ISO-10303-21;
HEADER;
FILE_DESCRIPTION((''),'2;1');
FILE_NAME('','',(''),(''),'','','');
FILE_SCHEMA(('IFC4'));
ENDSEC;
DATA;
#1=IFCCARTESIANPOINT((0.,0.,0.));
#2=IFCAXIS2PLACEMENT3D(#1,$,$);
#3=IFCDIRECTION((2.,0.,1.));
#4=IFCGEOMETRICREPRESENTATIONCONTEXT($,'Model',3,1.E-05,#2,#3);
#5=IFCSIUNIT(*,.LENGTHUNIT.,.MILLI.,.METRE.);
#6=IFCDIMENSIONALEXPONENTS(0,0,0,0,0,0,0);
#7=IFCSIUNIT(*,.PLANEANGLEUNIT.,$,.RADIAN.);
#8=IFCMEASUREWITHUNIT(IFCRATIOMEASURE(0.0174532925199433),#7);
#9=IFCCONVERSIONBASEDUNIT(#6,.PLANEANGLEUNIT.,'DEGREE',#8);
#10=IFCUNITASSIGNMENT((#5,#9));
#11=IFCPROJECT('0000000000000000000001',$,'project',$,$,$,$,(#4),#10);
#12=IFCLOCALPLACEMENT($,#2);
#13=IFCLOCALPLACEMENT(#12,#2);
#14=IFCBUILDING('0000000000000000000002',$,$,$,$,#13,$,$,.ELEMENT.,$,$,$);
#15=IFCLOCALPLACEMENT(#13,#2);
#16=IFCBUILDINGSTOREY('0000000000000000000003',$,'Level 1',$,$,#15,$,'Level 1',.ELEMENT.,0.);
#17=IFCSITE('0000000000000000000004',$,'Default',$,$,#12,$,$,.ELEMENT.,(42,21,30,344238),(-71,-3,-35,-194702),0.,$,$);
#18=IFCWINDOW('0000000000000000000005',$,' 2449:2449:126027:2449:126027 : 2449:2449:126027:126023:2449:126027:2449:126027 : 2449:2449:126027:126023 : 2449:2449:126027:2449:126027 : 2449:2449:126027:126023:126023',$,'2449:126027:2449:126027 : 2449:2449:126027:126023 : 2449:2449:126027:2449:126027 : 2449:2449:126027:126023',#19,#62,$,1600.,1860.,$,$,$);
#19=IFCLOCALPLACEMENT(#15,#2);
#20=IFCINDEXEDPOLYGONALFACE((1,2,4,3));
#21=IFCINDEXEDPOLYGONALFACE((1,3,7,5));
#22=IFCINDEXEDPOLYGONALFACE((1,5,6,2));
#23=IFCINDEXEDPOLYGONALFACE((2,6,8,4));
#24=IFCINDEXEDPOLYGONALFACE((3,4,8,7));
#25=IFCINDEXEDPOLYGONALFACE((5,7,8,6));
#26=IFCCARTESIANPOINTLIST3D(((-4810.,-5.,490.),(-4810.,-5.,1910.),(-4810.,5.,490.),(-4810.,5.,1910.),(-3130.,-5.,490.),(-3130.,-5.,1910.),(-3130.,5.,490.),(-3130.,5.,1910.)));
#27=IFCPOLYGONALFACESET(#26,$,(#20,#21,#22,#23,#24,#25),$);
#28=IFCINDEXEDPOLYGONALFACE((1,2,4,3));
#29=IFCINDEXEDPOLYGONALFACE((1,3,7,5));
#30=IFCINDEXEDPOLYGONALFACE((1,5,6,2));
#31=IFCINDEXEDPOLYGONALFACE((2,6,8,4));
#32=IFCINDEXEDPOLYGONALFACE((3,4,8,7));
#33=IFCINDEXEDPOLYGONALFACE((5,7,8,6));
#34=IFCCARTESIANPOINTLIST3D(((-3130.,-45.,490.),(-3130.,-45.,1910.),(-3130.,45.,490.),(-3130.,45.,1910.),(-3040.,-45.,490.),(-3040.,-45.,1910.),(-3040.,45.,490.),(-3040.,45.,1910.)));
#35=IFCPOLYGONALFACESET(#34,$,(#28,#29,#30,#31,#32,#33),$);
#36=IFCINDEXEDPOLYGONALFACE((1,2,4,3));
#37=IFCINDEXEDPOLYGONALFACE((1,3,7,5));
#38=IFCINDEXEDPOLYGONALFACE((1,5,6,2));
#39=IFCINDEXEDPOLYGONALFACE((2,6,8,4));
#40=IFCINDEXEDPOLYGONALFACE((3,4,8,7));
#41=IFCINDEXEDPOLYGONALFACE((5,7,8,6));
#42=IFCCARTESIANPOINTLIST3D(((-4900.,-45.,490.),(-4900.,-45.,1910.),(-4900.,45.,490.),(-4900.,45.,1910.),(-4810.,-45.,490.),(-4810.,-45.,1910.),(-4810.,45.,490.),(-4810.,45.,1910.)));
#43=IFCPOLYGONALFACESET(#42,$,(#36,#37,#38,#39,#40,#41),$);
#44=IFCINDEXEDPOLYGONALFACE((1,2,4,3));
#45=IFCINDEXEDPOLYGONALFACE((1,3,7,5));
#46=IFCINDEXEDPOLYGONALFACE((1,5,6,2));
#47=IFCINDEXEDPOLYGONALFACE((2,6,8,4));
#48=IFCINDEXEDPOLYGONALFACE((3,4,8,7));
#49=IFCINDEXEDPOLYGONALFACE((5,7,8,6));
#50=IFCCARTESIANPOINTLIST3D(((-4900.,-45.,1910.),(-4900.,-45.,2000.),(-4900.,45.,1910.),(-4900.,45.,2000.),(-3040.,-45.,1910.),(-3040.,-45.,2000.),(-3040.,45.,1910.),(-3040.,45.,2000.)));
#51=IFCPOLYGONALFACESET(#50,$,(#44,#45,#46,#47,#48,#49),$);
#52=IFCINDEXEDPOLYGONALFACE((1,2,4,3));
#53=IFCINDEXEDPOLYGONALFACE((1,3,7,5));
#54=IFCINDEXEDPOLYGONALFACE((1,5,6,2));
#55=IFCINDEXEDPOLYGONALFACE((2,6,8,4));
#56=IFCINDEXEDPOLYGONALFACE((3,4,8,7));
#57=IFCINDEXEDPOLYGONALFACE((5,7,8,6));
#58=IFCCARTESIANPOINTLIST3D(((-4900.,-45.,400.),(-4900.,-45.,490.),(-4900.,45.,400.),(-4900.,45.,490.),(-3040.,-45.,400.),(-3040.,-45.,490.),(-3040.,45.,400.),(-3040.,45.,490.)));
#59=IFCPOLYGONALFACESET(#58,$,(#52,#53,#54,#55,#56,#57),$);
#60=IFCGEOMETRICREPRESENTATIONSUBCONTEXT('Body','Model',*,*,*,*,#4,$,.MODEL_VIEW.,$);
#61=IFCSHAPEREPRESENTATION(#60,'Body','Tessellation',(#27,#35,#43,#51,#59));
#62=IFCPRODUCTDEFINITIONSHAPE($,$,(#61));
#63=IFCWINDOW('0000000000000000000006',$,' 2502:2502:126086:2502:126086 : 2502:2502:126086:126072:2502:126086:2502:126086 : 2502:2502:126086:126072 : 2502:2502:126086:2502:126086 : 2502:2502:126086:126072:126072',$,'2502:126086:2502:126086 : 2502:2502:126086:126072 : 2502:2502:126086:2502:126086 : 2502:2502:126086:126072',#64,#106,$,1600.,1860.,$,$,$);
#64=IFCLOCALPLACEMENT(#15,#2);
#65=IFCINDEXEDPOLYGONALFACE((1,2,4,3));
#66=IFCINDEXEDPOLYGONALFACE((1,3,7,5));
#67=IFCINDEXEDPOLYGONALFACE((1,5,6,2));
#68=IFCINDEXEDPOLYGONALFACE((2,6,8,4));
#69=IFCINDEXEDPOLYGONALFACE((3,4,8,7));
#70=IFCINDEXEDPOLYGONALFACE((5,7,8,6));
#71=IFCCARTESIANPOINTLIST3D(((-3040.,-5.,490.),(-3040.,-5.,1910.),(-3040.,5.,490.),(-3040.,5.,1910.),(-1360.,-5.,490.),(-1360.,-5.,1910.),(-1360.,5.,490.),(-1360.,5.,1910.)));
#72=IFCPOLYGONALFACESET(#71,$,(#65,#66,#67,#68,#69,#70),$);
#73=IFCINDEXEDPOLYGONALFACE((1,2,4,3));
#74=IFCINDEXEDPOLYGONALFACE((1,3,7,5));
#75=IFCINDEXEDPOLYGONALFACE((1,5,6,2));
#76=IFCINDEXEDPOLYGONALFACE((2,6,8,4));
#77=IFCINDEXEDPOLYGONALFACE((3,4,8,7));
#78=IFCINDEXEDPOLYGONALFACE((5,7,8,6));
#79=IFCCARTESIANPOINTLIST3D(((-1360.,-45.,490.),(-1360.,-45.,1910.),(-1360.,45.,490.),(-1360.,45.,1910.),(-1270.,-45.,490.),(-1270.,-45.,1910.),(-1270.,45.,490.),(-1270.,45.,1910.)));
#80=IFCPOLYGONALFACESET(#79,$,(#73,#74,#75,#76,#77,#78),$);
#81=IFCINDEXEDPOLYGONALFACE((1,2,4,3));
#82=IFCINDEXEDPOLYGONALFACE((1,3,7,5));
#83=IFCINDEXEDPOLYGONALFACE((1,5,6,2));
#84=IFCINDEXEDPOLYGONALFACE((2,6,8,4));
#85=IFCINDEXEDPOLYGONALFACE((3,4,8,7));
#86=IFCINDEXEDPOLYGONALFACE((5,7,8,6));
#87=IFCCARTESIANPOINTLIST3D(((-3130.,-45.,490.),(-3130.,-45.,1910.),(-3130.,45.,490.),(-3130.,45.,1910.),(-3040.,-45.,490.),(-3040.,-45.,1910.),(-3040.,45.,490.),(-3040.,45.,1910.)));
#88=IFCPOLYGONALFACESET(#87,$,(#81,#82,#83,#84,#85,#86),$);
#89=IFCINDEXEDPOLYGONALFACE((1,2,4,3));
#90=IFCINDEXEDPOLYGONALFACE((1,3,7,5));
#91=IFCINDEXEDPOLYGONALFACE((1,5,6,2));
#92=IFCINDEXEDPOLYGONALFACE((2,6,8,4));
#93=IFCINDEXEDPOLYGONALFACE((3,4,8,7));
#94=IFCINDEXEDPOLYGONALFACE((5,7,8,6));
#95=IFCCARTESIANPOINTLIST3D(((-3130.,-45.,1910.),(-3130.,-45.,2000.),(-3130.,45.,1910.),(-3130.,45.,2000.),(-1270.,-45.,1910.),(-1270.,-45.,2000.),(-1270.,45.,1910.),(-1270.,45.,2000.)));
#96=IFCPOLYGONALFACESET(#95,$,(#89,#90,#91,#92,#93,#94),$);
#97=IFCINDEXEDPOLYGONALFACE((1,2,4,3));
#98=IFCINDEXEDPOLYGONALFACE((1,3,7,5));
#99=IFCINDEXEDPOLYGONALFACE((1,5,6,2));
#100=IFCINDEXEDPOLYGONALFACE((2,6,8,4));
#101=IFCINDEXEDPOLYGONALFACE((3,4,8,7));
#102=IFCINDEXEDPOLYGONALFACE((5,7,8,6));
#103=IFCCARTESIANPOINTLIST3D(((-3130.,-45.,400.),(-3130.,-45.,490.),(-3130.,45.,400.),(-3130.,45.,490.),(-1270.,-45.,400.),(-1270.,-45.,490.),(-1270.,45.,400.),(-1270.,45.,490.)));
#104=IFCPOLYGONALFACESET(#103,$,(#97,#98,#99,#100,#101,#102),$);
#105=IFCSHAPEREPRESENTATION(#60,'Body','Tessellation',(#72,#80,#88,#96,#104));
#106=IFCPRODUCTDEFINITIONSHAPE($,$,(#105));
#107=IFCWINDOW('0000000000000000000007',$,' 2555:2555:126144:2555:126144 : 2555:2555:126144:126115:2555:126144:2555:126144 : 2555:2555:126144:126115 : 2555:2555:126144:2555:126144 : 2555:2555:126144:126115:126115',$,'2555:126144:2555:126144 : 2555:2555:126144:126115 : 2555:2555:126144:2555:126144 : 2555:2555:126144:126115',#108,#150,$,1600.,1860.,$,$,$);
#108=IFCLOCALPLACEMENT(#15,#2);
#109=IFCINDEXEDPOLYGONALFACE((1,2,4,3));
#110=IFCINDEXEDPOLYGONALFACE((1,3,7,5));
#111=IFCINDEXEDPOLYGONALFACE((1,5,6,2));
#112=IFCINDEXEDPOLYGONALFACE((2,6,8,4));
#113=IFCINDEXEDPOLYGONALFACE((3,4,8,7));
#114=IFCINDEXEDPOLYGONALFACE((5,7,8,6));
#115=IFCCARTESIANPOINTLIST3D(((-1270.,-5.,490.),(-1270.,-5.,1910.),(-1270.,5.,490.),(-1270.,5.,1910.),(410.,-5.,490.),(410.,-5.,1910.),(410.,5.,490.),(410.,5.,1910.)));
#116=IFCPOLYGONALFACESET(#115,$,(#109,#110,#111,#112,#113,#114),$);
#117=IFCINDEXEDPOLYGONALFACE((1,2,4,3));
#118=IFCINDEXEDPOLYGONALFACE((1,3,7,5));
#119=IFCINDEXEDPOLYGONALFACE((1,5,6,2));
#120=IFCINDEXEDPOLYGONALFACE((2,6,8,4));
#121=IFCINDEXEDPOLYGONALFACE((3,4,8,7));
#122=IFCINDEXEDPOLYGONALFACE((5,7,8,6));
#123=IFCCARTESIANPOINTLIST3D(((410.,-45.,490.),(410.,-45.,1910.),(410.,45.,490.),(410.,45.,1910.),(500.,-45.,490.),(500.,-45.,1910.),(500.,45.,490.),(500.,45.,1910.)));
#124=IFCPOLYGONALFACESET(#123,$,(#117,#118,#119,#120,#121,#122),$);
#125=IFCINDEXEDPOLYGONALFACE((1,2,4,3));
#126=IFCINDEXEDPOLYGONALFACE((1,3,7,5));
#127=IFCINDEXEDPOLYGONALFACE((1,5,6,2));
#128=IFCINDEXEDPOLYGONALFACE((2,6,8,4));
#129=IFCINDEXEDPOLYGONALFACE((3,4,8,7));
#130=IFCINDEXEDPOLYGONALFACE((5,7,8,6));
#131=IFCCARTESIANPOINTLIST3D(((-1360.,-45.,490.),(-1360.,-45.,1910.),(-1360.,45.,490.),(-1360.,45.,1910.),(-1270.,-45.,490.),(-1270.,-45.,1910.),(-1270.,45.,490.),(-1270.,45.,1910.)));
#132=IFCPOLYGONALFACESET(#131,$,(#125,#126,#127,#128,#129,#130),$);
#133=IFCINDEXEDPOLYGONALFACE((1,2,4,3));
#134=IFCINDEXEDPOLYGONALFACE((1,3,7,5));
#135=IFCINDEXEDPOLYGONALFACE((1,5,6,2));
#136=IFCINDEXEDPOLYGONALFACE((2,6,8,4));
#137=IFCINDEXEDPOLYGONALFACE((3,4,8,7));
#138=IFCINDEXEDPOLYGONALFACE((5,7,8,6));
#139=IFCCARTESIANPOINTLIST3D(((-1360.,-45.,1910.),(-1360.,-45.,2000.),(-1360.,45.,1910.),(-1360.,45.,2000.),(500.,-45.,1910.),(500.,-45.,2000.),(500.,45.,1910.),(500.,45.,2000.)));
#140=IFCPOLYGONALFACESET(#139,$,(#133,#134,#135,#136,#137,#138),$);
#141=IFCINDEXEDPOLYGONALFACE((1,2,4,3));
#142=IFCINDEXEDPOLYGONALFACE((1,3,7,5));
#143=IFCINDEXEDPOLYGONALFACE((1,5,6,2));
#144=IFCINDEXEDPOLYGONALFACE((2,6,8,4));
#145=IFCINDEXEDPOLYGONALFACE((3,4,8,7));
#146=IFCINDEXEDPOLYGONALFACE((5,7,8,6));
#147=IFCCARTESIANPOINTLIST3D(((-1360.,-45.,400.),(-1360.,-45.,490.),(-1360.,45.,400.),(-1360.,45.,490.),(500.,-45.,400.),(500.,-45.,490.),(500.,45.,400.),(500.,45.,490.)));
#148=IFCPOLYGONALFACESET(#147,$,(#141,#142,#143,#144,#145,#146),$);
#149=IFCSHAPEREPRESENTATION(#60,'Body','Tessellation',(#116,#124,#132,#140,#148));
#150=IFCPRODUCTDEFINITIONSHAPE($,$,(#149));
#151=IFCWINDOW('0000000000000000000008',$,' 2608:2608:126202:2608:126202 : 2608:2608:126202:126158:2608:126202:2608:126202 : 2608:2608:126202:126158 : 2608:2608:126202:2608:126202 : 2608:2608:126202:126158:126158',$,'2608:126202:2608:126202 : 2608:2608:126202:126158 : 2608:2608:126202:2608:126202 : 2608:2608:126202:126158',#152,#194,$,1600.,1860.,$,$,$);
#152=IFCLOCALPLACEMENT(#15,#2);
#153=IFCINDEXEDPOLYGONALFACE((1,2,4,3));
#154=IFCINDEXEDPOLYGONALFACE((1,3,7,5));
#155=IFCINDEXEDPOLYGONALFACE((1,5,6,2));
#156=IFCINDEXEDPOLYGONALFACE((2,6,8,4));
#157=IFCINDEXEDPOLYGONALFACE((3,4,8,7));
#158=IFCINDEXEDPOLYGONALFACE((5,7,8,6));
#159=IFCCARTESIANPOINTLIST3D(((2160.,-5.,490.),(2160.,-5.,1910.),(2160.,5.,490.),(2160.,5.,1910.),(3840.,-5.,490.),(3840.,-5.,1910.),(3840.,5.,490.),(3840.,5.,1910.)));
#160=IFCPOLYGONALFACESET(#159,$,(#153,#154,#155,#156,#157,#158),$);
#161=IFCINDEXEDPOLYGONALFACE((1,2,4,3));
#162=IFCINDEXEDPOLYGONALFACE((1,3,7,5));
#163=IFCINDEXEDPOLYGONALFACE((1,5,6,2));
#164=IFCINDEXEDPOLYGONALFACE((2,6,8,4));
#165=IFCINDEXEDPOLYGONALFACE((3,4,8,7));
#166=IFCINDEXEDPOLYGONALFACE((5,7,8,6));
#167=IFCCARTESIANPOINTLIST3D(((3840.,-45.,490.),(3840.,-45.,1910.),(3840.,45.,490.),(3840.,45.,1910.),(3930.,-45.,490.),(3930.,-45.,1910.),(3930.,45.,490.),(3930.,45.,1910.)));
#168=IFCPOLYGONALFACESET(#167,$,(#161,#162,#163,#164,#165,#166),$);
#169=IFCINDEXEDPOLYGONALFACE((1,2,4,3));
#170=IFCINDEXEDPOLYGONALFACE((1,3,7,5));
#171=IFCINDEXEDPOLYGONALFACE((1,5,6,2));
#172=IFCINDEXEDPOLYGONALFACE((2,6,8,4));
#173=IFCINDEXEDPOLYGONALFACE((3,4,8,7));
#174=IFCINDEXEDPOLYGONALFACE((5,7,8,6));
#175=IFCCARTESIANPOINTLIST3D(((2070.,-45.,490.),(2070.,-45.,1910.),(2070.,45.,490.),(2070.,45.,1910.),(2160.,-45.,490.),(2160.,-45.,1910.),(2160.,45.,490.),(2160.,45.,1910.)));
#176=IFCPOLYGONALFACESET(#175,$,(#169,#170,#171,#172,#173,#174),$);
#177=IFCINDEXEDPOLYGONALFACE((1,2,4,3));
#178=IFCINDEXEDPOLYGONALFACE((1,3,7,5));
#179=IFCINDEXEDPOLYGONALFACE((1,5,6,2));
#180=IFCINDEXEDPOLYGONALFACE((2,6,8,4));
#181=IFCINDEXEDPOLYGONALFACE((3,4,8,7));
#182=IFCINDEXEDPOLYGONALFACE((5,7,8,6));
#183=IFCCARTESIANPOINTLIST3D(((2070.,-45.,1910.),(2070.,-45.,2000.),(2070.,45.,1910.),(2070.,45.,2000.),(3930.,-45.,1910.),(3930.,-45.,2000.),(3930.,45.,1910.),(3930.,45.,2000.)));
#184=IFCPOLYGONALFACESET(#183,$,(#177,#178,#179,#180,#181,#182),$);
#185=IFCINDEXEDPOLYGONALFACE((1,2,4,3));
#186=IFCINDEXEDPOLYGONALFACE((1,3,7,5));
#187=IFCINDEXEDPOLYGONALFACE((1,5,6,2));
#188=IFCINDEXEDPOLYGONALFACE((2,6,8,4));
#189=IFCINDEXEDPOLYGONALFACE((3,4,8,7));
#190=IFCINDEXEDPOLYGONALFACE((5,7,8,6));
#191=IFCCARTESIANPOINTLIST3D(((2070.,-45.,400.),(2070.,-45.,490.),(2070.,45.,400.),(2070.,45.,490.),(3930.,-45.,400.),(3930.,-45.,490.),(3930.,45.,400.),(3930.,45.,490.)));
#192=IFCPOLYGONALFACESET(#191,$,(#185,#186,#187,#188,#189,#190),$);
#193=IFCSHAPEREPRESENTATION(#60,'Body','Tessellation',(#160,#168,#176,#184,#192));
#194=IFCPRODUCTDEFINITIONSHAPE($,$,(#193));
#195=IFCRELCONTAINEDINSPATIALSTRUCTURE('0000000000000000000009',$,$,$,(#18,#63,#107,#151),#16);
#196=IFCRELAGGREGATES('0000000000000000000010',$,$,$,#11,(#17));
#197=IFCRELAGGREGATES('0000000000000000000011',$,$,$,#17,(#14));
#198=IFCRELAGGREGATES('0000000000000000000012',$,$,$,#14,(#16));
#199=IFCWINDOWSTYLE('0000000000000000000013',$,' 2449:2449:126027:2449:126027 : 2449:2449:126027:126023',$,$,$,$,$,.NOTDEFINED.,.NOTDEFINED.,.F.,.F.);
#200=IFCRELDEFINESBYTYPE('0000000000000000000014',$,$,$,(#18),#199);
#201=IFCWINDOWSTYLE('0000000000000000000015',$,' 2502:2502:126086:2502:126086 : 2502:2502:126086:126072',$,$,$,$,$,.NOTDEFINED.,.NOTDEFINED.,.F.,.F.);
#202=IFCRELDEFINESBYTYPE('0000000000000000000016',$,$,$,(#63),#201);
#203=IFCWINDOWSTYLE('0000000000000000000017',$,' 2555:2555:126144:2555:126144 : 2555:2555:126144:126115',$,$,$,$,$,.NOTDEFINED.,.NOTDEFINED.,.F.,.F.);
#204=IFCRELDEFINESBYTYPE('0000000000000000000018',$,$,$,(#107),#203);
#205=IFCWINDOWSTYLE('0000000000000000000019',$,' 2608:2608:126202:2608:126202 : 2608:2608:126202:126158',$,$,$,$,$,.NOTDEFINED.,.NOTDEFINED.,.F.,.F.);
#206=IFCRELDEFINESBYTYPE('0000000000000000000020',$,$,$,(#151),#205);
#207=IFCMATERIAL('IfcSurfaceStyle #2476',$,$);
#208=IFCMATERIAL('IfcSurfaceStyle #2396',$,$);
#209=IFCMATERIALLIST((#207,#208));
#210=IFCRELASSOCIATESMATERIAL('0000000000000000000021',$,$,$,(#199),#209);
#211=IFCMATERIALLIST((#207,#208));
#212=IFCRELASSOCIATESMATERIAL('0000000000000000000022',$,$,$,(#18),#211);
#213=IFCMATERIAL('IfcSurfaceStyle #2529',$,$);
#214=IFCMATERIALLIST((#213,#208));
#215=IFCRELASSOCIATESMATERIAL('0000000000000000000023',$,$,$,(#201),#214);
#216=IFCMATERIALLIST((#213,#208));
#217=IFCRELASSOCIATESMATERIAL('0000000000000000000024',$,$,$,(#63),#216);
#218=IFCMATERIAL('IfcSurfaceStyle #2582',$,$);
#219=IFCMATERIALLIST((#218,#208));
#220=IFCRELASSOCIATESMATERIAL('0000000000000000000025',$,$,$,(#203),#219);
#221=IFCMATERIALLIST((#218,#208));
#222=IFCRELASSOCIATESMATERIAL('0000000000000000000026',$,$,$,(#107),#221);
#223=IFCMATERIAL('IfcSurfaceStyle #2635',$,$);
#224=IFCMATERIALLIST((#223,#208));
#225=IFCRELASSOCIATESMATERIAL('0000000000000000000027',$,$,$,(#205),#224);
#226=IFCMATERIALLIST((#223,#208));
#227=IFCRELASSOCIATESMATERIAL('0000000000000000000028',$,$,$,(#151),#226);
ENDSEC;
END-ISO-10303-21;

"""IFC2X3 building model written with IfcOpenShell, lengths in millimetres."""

from ifc_helpers import new_model, entity, si_unit, converted_unit, direction, frame, frame_2d, origin, origin_2d_with_axis, place, context, subcontext, project, spatial, rectangle, extrude, source, transform, mapped, material, material_list, type_object, type_shapes, element, save


model = new_model("IFC2X3")

# Units and contexts
model_context = context("Model", 3, precision=1e-05, world=origin(), true_north=direction((2.0, 0.0, 1.0)))
body_context = subcontext(model_context, "Body", "Model", "MODEL_VIEW")
ifc_project = project(units=[si_unit("LENGTHUNIT", "METRE", prefix="MILLI"), converted_unit("PLANEANGLEUNIT", "DEGREE", entity("IfcRatioMeasure", 0.0174532925199433), si_unit("PLANEANGLEUNIT", "RADIAN"), dimensions=[0, 0, 0, 0, 0, 0, 0])], contexts=[model_context])

# Site, building, storey
site_placement = place(None, origin())
site = spatial("IfcSite", under=ifc_project, at=site_placement, Name="Default", CompositionType="ELEMENT", RefLatitude=(42, 21, 30, 344238), RefLongitude=(-71, -3, -35, -194702), RefElevation=0.0)
building_placement = place(site_placement, origin())
building = spatial("IfcBuilding", under=site, at=building_placement, CompositionType="ELEMENT")
storey_placement = place(building_placement, origin())
storey = spatial("IfcBuildingStorey", under=building, at=storey_placement, Name="Level 1", LongName="Level 1", CompositionType="ELEMENT", Elevation=0.0)

# Windows
ifc_material_1 = material(Name="IfcSurfaceStyle #2476")
ifc_material_2 = material(Name="IfcSurfaceStyle #2396")
ifc_material_list_1 = material_list([ifc_material_1, ifc_material_2])
ifc_material_list_2 = material_list([ifc_material_1, ifc_material_2])
window_style_1 = type_object("IfcWindowStyle", Name=" 2449:2449:126027:2449:126027 : 2449:2449:126027:126023", ConstructionType="NOTDEFINED", OperationType="NOTDEFINED", ParameterTakesPrecedence=False, Sizeable=False, material=ifc_material_list_2)
shared_shape_1 = source(origin(), body_context, "Body", "SweptSolid", [
    extrude(rectangle(XDim=10.0, YDim=1680.0, at=origin_2d_with_axis()), frame((-3970.0, 0.0, 490.0), z_axis=(0.0, 0.0, 1.0), x_axis=(0.0, -1.0, 0.0)), (0.0, 0.0, 1.0), 1420.0),
    extrude(rectangle(XDim=90.0, YDim=90.0, at=origin_2d_with_axis()), frame((-3085.0, 0.0, 490.0), z_axis=(0.0, 0.0, 1.0), x_axis=(0.0, -1.0, 0.0)), (0.0, 0.0, 1.0), 1420.0),
    extrude(rectangle(XDim=90.0, YDim=90.0, at=frame_2d((0.0, 0.0), x_axis=(1.0, 0.0))), frame((-4855.0, 0.0, 490.0), z_axis=(0.0, 0.0, 1.0), x_axis=(0.0, -1.0, 0.0)), (0.0, 0.0, 1.0), 1420.0),
    extrude(rectangle(XDim=90.0, YDim=1860.0, at=frame_2d((0.0, 0.0), x_axis=(1.0, 0.0))), frame((-3970.0, 0.0, 1910.0), z_axis=(0.0, 0.0, 1.0), x_axis=(0.0, -1.0, 0.0)), (0.0, 0.0, 1.0), 90.0),
    extrude(rectangle(XDim=90.0, YDim=1860.0, at=frame_2d((0.0, 0.0), x_axis=(1.0, 0.0))), frame((-3970.0, 0.0, 400.0), z_axis=(0.0, 0.0, 1.0), x_axis=(0.0, -1.0, 0.0)), (0.0, 0.0, 1.0), 90.0),
])
type_shapes(window_style_1, [shared_shape_1])
window_1_placement = place(storey_placement, origin())
element("IfcWindow", 1, at=window_1_placement, inside=storey, type_object=window_style_1, material=ifc_material_list_1, Name=" 2449:2449:126027:2449:126027 : 2449:2449:126027:126023:2449:126027:2449:126027 : 2449:2449:126027:126023 : 2449:2449:126027:2449:126027 : 2449:2449:126027:126023:126023", ObjectType="2449:126027:2449:126027 : 2449:2449:126027:126023 : 2449:2449:126027:2449:126027 : 2449:2449:126027:126023", OverallHeight=1600.0, OverallWidth=1860.0, context=body_context, shape_type="MappedRepresentation", body=[
    mapped(shared_shape_1, transform((0.0, 0.0, 0.0), scale=1.0)),
])
ifc_material_3 = material(Name="IfcSurfaceStyle #2529")
ifc_material_list_3 = material_list([ifc_material_3, ifc_material_2])
ifc_material_list_4 = material_list([ifc_material_3, ifc_material_2])
window_style_2 = type_object("IfcWindowStyle", Name=" 2502:2502:126086:2502:126086 : 2502:2502:126086:126072", ConstructionType="NOTDEFINED", OperationType="NOTDEFINED", ParameterTakesPrecedence=False, Sizeable=False, material=ifc_material_list_4)
shared_shape_2 = source(origin(), body_context, "Body", "SweptSolid", [
    extrude(rectangle(XDim=10.0, YDim=1680.0, at=origin_2d_with_axis()), frame((-2200.0, 0.0, 490.0), z_axis=(0.0, 0.0, 1.0), x_axis=(0.0, -1.0, 0.0)), (0.0, 0.0, 1.0), 1420.0),
    extrude(rectangle(XDim=90.0, YDim=90.0, at=origin_2d_with_axis()), frame((-1315.0, 0.0, 490.0), z_axis=(0.0, 0.0, 1.0), x_axis=(0.0, -1.0, 0.0)), (0.0, 0.0, 1.0), 1420.0),
    extrude(rectangle(XDim=90.0, YDim=90.0, at=origin_2d_with_axis()), frame((-3085.0, 0.0, 490.0), z_axis=(0.0, 0.0, 1.0), x_axis=(0.0, -1.0, 0.0)), (0.0, 0.0, 1.0), 1420.0),
    extrude(rectangle(XDim=90.0, YDim=1860.0, at=frame_2d((0.0, 0.0), x_axis=(1.0, 0.0))), frame((-2200.0, 0.0, 1910.0), z_axis=(0.0, 0.0, 1.0), x_axis=(0.0, -1.0, 0.0)), (0.0, 0.0, 1.0), 90.0),
    extrude(rectangle(XDim=90.0, YDim=1860.0, at=frame_2d((0.0, 0.0), x_axis=(1.0, 0.0))), frame((-2200.0, 0.0, 400.0), z_axis=(0.0, 0.0, 1.0), x_axis=(0.0, -1.0, 0.0)), (0.0, 0.0, 1.0), 90.0),
])
type_shapes(window_style_2, [shared_shape_2])
window_2_placement = place(storey_placement, origin())
element("IfcWindow", 2, at=window_2_placement, inside=storey, type_object=window_style_2, material=ifc_material_list_3, Name=" 2502:2502:126086:2502:126086 : 2502:2502:126086:126072:2502:126086:2502:126086 : 2502:2502:126086:126072 : 2502:2502:126086:2502:126086 : 2502:2502:126086:126072:126072", ObjectType="2502:126086:2502:126086 : 2502:2502:126086:126072 : 2502:2502:126086:2502:126086 : 2502:2502:126086:126072", OverallHeight=1600.0, OverallWidth=1860.0, context=body_context, shape_type="MappedRepresentation", body=[
    mapped(shared_shape_2, transform((0.0, 0.0, 0.0), scale=1.0)),
])
ifc_material_4 = material(Name="IfcSurfaceStyle #2582")
ifc_material_list_5 = material_list([ifc_material_4, ifc_material_2])
ifc_material_list_6 = material_list([ifc_material_4, ifc_material_2])
window_style_3 = type_object("IfcWindowStyle", Name=" 2555:2555:126144:2555:126144 : 2555:2555:126144:126115", ConstructionType="NOTDEFINED", OperationType="NOTDEFINED", ParameterTakesPrecedence=False, Sizeable=False, material=ifc_material_list_6)
shared_shape_3 = source(origin(), body_context, "Body", "SweptSolid", [
    extrude(rectangle(XDim=10.0, YDim=1680.0, at=origin_2d_with_axis()), frame((-430.0, 0.0, 490.0), z_axis=(0.0, 0.0, 1.0), x_axis=(0.0, -1.0, 0.0)), (0.0, 0.0, 1.0), 1420.0),
    extrude(rectangle(XDim=90.0, YDim=90.0, at=frame_2d((0.0, 0.0), x_axis=(1.0, 0.0))), frame((455.0, 0.0, 490.0), z_axis=(0.0, 0.0, 1.0), x_axis=(0.0, -1.0, 0.0)), (0.0, 0.0, 1.0), 1420.0),
    extrude(rectangle(XDim=90.0, YDim=90.0, at=origin_2d_with_axis()), frame((-1315.0, 0.0, 490.0), z_axis=(0.0, 0.0, 1.0), x_axis=(0.0, -1.0, 0.0)), (0.0, 0.0, 1.0), 1420.0),
    extrude(rectangle(XDim=90.0, YDim=1860.0, at=origin_2d_with_axis()), frame((-430.0, 0.0, 1910.0), z_axis=(0.0, 0.0, 1.0), x_axis=(0.0, -1.0, 0.0)), (0.0, 0.0, 1.0), 90.0),
    extrude(rectangle(XDim=90.0, YDim=1860.0, at=origin_2d_with_axis()), frame((-430.0, 0.0, 400.0), z_axis=(0.0, 0.0, 1.0), x_axis=(0.0, -1.0, 0.0)), (0.0, 0.0, 1.0), 90.0),
])
type_shapes(window_style_3, [shared_shape_3])
window_3_placement = place(storey_placement, origin())
element("IfcWindow", 3, at=window_3_placement, inside=storey, type_object=window_style_3, material=ifc_material_list_5, Name=" 2555:2555:126144:2555:126144 : 2555:2555:126144:126115:2555:126144:2555:126144 : 2555:2555:126144:126115 : 2555:2555:126144:2555:126144 : 2555:2555:126144:126115:126115", ObjectType="2555:126144:2555:126144 : 2555:2555:126144:126115 : 2555:2555:126144:2555:126144 : 2555:2555:126144:126115", OverallHeight=1600.0, OverallWidth=1860.0, context=body_context, shape_type="MappedRepresentation", body=[
    mapped(shared_shape_3, transform((0.0, 0.0, 0.0), scale=1.0)),
])
ifc_material_5 = material(Name="IfcSurfaceStyle #2635")
ifc_material_list_7 = material_list([ifc_material_5, ifc_material_2])
ifc_material_list_8 = material_list([ifc_material_5, ifc_material_2])
window_style_4 = type_object("IfcWindowStyle", Name=" 2608:2608:126202:2608:126202 : 2608:2608:126202:126158", ConstructionType="NOTDEFINED", OperationType="NOTDEFINED", ParameterTakesPrecedence=False, Sizeable=False, material=ifc_material_list_8)
shared_shape_4 = source(origin(), body_context, "Body", "SweptSolid", [
    extrude(rectangle(XDim=10.0, YDim=1680.0, at=frame_2d((0.0, 0.0), x_axis=(1.0, 0.0))), frame((3000.0, 0.0, 490.0), z_axis=(0.0, 0.0, 1.0), x_axis=(0.0, -1.0, 0.0)), (0.0, 0.0, 1.0), 1420.0),
    extrude(rectangle(XDim=90.0, YDim=90.0, at=frame_2d((0.0, 0.0), x_axis=(1.0, 0.0))), frame((3885.0, 0.0, 490.0), z_axis=(0.0, 0.0, 1.0), x_axis=(0.0, -1.0, 0.0)), (0.0, 0.0, 1.0), 1420.0),
    extrude(rectangle(XDim=90.0, YDim=90.0, at=origin_2d_with_axis()), frame((2115.0, 0.0, 490.0), z_axis=(0.0, 0.0, 1.0), x_axis=(0.0, -1.0, 0.0)), (0.0, 0.0, 1.0), 1420.0),
    extrude(rectangle(XDim=90.0, YDim=1860.0, at=frame_2d((0.0, 0.0), x_axis=(1.0, 0.0))), frame((3000.0, 0.0, 1910.0), z_axis=(0.0, 0.0, 1.0), x_axis=(0.0, -1.0, 0.0)), (0.0, 0.0, 1.0), 90.0),
    extrude(rectangle(XDim=90.0, YDim=1860.0, at=frame_2d((0.0, 0.0), x_axis=(1.0, 0.0))), frame((3000.0, 0.0, 400.0), z_axis=(0.0, 0.0, 1.0), x_axis=(0.0, -1.0, 0.0)), (0.0, 0.0, 1.0), 90.0),
])
type_shapes(window_style_4, [shared_shape_4])
window_4_placement = place(storey_placement, origin())
element("IfcWindow", 4, at=window_4_placement, inside=storey, type_object=window_style_4, material=ifc_material_list_7, Name=" 2608:2608:126202:2608:126202 : 2608:2608:126202:126158:2608:126202:2608:126202 : 2608:2608:126202:126158 : 2608:2608:126202:2608:126202 : 2608:2608:126202:126158:126158", ObjectType="2608:126202:2608:126202 : 2608:2608:126202:126158 : 2608:2608:126202:2608:126202 : 2608:2608:126202:126158", OverallHeight=1600.0, OverallWidth=1860.0, context=body_context, shape_type="MappedRepresentation", body=[
    mapped(shared_shape_4, transform((0.0, 0.0, 0.0), scale=1.0)),
])

save(model, "model.ifc")
